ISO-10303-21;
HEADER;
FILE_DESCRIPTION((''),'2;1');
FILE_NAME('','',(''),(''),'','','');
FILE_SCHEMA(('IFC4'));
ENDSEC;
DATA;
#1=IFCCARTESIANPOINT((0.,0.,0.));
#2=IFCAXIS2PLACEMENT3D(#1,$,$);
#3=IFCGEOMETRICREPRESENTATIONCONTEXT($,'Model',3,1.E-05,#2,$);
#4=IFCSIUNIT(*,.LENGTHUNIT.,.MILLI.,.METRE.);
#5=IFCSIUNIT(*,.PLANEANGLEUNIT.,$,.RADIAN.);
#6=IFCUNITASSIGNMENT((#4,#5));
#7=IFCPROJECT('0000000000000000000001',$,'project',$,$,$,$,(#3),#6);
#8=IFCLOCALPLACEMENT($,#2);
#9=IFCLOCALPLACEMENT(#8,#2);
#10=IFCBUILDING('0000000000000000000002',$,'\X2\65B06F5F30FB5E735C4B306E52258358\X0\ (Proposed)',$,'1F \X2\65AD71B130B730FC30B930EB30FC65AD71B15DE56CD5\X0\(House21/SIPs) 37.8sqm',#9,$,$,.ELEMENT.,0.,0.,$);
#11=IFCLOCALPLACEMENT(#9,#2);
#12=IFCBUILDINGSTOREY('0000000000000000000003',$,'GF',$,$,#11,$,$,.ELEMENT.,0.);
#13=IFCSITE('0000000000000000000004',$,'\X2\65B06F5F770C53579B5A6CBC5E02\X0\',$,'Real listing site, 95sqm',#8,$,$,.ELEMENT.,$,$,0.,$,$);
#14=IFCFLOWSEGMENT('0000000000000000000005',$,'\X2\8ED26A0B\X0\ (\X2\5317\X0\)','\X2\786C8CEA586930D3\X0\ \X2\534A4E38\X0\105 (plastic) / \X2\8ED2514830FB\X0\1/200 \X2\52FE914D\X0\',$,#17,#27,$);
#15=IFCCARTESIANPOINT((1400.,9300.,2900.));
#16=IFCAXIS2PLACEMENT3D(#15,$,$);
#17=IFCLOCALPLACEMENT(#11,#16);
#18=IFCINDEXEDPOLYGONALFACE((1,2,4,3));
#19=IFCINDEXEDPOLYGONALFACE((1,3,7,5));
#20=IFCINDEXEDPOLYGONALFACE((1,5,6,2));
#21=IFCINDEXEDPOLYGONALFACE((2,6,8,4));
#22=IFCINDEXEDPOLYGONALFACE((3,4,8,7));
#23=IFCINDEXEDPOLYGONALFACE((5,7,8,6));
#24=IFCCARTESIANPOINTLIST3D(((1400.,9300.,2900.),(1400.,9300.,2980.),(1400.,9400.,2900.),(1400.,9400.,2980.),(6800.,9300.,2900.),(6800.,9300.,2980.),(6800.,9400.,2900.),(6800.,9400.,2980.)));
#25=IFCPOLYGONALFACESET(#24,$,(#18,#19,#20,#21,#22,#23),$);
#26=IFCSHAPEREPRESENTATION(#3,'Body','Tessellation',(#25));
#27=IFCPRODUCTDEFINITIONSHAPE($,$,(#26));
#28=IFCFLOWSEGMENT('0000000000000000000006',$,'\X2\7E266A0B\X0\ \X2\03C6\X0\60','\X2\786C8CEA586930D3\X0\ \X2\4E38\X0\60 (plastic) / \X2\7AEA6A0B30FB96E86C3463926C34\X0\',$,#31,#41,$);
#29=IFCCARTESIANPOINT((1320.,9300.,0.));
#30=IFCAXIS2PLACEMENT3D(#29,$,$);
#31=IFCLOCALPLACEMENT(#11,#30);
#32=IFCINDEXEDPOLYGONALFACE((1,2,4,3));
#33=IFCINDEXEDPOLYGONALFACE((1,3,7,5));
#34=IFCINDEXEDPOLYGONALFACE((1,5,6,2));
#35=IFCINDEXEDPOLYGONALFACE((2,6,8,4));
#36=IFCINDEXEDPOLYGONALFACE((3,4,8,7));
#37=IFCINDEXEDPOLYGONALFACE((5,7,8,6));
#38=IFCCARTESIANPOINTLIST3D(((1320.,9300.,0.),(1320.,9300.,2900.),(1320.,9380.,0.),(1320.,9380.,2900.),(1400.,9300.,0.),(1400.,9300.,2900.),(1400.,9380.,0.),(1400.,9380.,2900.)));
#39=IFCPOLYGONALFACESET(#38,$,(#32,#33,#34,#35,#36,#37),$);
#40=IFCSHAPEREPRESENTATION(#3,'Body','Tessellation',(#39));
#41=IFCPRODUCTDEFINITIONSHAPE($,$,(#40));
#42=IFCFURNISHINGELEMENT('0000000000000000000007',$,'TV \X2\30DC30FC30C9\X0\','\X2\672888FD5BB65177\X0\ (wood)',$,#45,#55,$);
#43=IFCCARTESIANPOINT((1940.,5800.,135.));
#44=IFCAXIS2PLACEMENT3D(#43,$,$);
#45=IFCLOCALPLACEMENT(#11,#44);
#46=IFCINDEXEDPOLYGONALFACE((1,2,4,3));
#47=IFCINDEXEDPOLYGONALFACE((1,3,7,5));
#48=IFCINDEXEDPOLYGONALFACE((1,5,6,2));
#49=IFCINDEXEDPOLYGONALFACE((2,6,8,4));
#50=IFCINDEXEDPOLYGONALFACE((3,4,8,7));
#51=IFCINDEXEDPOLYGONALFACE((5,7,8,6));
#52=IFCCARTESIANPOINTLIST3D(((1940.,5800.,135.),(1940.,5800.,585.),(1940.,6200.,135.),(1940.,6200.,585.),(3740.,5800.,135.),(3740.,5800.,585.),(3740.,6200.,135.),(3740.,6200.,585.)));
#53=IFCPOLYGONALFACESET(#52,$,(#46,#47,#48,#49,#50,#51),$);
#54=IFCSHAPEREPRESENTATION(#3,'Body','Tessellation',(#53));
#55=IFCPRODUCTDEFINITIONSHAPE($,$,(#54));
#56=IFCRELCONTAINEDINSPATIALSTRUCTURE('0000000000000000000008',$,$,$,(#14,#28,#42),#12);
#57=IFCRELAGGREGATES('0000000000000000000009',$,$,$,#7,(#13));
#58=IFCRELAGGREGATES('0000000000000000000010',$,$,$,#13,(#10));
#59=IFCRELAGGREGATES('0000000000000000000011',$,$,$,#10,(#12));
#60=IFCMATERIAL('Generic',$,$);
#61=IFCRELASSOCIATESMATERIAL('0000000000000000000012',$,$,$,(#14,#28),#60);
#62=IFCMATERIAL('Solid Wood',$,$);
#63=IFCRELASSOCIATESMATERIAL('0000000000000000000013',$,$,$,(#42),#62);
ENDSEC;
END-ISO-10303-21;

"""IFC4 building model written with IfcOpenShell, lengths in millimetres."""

from ifc_helpers import new_model, si_unit, frame, frame_2d, origin, place, context, project, spatial, rectangle, extrude, material, element, save


model = new_model("IFC4")

# Units and contexts
model_context = context("Model", 3, precision=1e-05, world=origin())
ifc_project = project(units=[si_unit("LENGTHUNIT", "METRE", prefix="MILLI"), si_unit("PLANEANGLEUNIT", "RADIAN")], contexts=[model_context])

# Site, building, storey
site_placement = place(None, origin())
site = spatial("IfcSite", under=ifc_project, at=site_placement, Name="新潟県南魚沼市", ObjectType="Real listing site, 95sqm", CompositionType="ELEMENT", RefElevation=0.0)
building_placement = place(site_placement, origin())
building = spatial("IfcBuilding", under=site, at=building_placement, Name="新潟・平屋の別荘 (Proposed)", ObjectType="1F 断熱シースルー断熱工法(House21/SIPs) 37.8sqm", CompositionType="ELEMENT", ElevationOfRefHeight=0.0, ElevationOfTerrain=0.0)
storey_placement = place(building_placement, origin())
storey = spatial("IfcBuildingStorey", under=building, at=storey_placement, Name="GF", CompositionType="ELEMENT", Elevation=0.0)

# Shared definitions
ifc_material_1 = material(Name="Solid Wood")

# Shared definitions
ifc_material_2 = material(Name="Generic")

# Flow segments
flow_segment_1_placement = place(storey_placement, frame((1400.0, 9300.0, 2900.0)))
element("IfcFlowSegment", 1, at=flow_segment_1_placement, inside=storey, material=ifc_material_2, Name="軒樋 (北)", Description="硬質塩ビ 半丸105 (plastic) / 軒先・1/200 勾配", context=model_context, shape_type="SweptSolid", body=[
    extrude(rectangle(XDim=5400.0, YDim=100.0, at=frame_2d((2700.0, 50.0))), frame((1400.0, 9300.0, 2900.0)), (0.0, 0.0, 1.0), 80.0),
])
flow_segment_2_placement = place(storey_placement, frame((1320.0, 9300.0, 0.0)))
element("IfcFlowSegment", 2, at=flow_segment_2_placement, inside=storey, material=ifc_material_2, Name="縦樋 φ60", Description="硬質塩ビ 丸60 (plastic) / 竪樋・雨水排水", context=model_context, shape_type="SweptSolid", body=[
    extrude(rectangle(XDim=80.0, YDim=80.0, at=frame_2d((40.0, 40.0))), frame((1320.0, 9300.0, 0.0)), (0.0, 0.0, 1.0), 2900.0),
])

# Furnishing element
furnishing_placement = place(storey_placement, frame((1940.0, 5800.0, 135.0)))
element("IfcFurnishingElement", 3, at=furnishing_placement, inside=storey, material=ifc_material_1, Name="TV ボード", Description="木製家具 (wood)", context=model_context, shape_type="SweptSolid", body=[
    extrude(rectangle(XDim=1800.0, YDim=400.0, at=frame_2d((900.0, 200.0))), frame((1940.0, 5800.0, 135.0)), (0.0, 0.0, 1.0), 450.0),
])

save(model, "model.ifc")
